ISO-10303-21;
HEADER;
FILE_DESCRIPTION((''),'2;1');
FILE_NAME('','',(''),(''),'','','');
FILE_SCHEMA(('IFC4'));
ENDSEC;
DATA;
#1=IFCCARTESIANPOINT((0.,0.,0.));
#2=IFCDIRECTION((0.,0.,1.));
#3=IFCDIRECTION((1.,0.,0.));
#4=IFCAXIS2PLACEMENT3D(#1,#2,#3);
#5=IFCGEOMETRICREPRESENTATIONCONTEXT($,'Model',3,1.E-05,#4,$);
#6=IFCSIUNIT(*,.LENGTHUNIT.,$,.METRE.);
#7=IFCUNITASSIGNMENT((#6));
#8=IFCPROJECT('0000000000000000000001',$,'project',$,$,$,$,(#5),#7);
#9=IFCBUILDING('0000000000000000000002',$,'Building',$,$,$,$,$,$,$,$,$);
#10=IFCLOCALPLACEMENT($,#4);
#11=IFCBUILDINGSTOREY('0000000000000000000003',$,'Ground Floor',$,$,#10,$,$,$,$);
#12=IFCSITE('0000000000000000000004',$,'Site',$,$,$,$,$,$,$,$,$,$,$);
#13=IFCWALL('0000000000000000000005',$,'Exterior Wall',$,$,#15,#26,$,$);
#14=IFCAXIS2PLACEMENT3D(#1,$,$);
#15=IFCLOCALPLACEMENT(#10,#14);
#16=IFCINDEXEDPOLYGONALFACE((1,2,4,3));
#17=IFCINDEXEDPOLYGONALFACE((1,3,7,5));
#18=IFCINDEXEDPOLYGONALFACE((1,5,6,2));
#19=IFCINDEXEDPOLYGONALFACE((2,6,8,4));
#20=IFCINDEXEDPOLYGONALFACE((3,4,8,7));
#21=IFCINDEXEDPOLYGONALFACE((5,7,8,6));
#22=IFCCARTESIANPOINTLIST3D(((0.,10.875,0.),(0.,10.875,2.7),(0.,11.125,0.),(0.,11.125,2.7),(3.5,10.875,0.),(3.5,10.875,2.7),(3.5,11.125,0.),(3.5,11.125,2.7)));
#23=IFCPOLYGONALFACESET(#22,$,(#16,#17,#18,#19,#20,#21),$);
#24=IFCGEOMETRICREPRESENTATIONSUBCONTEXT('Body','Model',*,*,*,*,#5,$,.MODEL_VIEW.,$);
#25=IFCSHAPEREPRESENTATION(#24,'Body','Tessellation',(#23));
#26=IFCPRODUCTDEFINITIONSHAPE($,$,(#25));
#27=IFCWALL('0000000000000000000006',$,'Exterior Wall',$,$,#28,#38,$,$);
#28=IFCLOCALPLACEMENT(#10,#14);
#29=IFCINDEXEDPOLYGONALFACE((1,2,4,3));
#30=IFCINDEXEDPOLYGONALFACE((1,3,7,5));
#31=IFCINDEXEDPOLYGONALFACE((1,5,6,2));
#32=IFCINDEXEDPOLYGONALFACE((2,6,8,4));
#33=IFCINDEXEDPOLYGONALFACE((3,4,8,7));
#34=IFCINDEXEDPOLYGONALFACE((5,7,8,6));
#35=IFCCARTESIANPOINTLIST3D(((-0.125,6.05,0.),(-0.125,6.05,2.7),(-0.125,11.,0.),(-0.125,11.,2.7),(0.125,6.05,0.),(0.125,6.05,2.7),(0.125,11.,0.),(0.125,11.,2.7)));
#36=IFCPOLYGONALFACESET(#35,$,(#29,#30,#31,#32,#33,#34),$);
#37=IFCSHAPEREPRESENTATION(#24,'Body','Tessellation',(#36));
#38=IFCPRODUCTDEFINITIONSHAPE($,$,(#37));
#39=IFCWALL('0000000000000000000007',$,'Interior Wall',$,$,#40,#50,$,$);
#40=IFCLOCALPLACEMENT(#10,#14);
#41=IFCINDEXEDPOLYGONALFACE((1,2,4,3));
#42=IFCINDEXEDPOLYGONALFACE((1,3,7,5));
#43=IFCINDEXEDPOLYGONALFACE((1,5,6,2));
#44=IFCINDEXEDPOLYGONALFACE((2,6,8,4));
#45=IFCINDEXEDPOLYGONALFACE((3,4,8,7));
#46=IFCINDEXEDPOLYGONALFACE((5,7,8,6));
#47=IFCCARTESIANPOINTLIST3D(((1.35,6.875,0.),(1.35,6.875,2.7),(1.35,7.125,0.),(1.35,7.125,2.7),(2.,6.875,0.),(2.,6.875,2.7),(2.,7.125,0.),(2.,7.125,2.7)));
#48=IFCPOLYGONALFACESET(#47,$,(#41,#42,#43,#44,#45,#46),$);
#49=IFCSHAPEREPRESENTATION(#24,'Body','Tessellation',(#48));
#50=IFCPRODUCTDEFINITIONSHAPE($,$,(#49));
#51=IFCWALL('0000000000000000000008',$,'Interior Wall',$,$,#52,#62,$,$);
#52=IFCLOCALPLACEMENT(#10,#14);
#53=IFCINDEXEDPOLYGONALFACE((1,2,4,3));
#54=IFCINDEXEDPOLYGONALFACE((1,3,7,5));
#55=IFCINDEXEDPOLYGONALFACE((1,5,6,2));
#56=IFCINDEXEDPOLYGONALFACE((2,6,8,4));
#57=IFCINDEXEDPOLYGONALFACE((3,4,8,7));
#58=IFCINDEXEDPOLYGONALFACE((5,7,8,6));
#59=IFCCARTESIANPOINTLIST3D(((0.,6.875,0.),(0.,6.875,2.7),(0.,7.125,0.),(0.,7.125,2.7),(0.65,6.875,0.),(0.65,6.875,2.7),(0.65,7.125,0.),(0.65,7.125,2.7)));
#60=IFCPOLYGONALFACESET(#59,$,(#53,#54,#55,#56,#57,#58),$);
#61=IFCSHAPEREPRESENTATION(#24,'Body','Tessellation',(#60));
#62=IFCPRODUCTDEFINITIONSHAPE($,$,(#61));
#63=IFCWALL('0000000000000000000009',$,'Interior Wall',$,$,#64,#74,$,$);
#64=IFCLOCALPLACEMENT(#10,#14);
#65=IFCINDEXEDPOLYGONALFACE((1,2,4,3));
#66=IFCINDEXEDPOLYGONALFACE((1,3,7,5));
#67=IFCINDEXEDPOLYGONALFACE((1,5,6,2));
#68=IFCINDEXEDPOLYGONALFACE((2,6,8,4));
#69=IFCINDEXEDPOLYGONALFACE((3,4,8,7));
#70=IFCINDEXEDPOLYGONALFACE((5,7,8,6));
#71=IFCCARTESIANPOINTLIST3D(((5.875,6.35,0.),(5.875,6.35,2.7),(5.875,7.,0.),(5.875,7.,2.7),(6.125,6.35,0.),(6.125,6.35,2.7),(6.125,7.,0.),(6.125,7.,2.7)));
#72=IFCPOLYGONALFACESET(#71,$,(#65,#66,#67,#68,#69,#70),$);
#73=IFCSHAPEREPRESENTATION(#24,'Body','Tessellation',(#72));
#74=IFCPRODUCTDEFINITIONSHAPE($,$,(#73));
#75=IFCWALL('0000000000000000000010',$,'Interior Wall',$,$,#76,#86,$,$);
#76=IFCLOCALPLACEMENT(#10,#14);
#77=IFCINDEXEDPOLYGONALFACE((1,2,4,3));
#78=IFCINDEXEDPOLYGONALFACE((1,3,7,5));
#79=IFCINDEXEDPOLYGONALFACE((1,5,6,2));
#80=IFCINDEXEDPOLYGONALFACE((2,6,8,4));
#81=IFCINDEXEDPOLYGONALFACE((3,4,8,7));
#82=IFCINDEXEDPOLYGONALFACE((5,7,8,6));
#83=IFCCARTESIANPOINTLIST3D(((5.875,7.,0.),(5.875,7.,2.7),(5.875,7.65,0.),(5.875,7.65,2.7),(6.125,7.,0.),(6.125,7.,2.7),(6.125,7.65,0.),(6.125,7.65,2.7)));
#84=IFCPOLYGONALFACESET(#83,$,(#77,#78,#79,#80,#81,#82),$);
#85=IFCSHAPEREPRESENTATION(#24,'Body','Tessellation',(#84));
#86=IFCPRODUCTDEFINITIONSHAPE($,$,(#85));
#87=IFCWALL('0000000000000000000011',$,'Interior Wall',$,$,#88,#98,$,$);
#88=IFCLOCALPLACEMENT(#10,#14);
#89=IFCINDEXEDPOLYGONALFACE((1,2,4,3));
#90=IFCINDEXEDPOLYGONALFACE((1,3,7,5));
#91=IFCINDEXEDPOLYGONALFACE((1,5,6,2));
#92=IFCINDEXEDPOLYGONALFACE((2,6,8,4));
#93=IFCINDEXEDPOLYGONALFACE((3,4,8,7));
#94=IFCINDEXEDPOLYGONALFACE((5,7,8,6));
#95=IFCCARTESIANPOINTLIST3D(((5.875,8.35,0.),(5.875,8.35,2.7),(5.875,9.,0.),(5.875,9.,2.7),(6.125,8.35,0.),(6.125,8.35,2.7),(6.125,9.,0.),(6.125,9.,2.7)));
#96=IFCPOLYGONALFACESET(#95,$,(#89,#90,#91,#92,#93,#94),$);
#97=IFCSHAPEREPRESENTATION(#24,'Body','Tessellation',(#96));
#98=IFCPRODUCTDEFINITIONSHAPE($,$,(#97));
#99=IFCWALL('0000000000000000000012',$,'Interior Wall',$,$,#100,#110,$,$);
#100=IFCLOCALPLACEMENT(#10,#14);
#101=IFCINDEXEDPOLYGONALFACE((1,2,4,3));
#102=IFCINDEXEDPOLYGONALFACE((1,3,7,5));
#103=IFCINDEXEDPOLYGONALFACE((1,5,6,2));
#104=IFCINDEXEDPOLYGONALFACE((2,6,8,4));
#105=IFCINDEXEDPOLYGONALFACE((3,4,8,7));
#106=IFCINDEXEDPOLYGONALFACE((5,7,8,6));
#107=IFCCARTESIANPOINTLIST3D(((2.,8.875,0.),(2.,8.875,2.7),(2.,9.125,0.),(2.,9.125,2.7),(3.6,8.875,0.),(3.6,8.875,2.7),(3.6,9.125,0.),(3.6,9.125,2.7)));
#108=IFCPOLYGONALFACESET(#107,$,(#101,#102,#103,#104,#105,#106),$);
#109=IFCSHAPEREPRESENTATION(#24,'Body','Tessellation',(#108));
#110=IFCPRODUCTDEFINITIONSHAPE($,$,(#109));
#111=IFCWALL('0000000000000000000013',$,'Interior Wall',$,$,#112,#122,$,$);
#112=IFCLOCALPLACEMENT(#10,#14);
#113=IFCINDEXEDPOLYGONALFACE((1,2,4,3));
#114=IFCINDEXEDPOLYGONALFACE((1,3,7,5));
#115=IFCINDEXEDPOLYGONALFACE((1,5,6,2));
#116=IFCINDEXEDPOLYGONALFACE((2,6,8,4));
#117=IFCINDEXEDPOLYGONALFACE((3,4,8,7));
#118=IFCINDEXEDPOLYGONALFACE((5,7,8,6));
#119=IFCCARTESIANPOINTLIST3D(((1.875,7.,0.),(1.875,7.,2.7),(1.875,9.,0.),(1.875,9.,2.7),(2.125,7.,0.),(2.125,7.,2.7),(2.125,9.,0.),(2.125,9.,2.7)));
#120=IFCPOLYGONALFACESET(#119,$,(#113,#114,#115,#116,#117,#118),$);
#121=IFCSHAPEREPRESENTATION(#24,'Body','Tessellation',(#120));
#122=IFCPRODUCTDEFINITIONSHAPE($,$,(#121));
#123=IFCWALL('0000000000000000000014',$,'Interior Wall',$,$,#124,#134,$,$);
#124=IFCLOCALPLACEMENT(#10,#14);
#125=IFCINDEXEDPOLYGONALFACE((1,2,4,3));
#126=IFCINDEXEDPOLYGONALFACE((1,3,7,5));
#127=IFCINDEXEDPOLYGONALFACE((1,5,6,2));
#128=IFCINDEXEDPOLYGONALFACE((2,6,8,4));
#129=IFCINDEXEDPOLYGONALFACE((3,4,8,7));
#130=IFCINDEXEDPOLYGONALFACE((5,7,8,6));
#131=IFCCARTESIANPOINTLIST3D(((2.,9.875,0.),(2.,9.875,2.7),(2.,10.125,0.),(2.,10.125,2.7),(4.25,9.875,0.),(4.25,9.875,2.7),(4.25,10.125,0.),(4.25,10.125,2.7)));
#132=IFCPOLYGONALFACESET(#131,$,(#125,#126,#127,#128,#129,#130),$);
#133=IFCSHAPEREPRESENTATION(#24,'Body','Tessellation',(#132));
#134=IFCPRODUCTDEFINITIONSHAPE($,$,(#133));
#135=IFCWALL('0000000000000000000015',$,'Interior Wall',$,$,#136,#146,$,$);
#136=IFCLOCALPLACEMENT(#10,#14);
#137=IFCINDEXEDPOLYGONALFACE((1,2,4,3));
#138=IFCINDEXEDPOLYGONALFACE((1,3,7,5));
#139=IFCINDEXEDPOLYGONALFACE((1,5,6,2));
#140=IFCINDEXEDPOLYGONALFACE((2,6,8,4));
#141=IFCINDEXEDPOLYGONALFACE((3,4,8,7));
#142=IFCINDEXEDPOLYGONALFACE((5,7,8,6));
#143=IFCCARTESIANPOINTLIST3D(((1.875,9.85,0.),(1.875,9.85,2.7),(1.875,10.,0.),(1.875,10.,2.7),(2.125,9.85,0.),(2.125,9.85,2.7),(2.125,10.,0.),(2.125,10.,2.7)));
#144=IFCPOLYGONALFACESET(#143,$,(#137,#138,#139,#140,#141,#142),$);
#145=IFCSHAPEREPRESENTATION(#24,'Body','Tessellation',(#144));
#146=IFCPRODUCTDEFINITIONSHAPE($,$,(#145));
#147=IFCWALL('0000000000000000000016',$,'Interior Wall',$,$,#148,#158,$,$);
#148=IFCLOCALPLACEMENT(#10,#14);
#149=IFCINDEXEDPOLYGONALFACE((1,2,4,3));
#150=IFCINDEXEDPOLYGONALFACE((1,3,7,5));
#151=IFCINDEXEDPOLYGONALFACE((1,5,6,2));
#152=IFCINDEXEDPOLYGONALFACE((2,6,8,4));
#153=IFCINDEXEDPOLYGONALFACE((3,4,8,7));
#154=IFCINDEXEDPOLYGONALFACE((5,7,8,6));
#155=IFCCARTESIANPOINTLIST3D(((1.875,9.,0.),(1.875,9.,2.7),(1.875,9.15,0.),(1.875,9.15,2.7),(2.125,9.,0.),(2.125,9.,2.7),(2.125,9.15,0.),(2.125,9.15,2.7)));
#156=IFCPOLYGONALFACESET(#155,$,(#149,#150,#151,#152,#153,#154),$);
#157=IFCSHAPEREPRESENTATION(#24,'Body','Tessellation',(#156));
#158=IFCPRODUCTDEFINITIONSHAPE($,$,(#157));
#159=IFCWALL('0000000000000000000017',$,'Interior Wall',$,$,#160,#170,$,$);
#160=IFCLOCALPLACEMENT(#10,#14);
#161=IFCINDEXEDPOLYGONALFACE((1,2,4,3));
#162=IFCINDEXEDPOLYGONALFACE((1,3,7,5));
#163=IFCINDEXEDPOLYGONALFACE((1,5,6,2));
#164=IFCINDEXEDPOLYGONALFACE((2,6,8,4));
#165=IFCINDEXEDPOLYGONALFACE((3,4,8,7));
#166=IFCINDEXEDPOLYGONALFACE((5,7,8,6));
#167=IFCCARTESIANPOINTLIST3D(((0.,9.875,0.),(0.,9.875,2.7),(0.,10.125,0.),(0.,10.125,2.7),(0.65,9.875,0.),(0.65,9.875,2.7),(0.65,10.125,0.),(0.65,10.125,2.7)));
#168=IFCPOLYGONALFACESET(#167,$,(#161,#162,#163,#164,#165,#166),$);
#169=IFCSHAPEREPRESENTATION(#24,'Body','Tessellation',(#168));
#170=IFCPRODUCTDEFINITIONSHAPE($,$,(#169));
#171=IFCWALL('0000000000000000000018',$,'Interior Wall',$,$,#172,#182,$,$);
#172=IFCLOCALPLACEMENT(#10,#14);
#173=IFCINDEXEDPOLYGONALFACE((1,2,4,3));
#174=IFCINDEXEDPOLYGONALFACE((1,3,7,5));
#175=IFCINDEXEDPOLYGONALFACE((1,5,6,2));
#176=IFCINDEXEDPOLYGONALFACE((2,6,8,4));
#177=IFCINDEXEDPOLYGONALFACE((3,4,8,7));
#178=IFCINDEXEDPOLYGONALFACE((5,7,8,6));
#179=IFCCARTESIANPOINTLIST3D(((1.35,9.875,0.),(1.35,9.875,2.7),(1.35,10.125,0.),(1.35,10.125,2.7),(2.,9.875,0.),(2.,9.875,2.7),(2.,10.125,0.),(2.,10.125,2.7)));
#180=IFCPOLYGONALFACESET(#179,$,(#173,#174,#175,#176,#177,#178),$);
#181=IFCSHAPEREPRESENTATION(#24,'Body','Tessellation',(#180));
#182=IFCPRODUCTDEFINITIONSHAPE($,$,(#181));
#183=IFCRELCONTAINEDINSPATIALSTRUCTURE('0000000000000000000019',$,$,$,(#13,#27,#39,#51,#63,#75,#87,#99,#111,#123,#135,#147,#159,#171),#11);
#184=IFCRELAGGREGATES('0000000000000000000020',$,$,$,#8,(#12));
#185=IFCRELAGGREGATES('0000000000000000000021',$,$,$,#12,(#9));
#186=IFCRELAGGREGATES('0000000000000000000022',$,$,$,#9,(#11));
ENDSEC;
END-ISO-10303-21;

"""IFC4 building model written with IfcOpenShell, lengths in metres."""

from ifc_helpers import new_model, si_unit, frame, origin_with_axes, place, context, subcontext, project, spatial, indexed_curve, outline, extrude, element, save


model = new_model("IFC4")

# Units and contexts
model_context = context("Model", 3, precision=1e-05, world=origin_with_axes())
body_context = subcontext(model_context, "Body", "Model", "MODEL_VIEW")
ifc_project = project(units=[si_unit("LENGTHUNIT", "METRE")], contexts=[model_context])

# Site, building, storey
site = spatial("IfcSite", under=ifc_project, Name="Site")
building = spatial("IfcBuilding", under=site, Name="Building")
storey_placement = place(None, origin_with_axes())
storey = spatial("IfcBuildingStorey", under=building, at=storey_placement, Name="Ground Floor")

# Walls
wall_1_placement = place(storey_placement, frame((3.5, 11.0, 0.0), z_axis=(0.0, 0.0, 1.0), x_axis=(-1.0, 0.0, 0.0)))
element("IfcWall", 1, at=wall_1_placement, inside=storey, Name="Exterior Wall", context=body_context, shape_type="SweptSolid", body=[
    extrude(outline(indexed_curve([(0.0, 0.0), (0.0, 0.25), (3.5, 0.25), (3.5, 0.0), (0.0, 0.0)], self_intersect=False)), frame((0.0, -0.125, 0.0), z_axis=(0.0, 0.0, 1.0), x_axis=(1.0, 0.0, 0.0)), (0.0, 0.0, 1.0), 2.7),
])
wall_2_placement = place(storey_placement, frame((0.0, 11.0, 0.0), z_axis=(0.0, 0.0, 1.0), x_axis=(0.0, -1.0, 0.0)))
element("IfcWall", 2, at=wall_2_placement, inside=storey, Name="Exterior Wall", context=body_context, shape_type="SweptSolid", body=[
    extrude(outline(indexed_curve([(0.0, 0.0), (0.0, 0.25), (4.95, 0.25), (4.95, 0.0), (0.0, 0.0)], self_intersect=False)), frame((0.0, -0.125, 0.0), z_axis=(0.0, 0.0, 1.0), x_axis=(1.0, 0.0, 0.0)), (0.0, 0.0, 1.0), 2.7),
])
for number, where, z_axis, x_axis, name in (
    (3, (2.0, 7.0, 0.0), (0.0, 0.0, 1.0), (-1.0, 0.0, 0.0), "Interior Wall"),
    (4, (0.65, 7.0, 0.0), (0.0, 0.0, 1.0), (-1.0, 0.0, 0.0), "Interior Wall"),
):
    element("IfcWall", number, at=place(storey_placement, frame(where, z_axis=z_axis, x_axis=x_axis)), inside=storey, Name=name, context=body_context, shape_type="SweptSolid", body=[
        extrude(outline(indexed_curve([(0.0, 0.0), (0.0, 0.25), (0.65, 0.25), (0.65, 0.0), (0.0, 0.0)], self_intersect=False)), frame((0.0, -0.125, 0.0), z_axis=(0.0, 0.0, 1.0), x_axis=(1.0, 0.0, 0.0)), (0.0, 0.0, 1.0), 2.7),
    ])
for number, where, z_axis, x_axis, name in (
    (5, (6.0, 6.35, 0.0), (0.0, 0.0, 1.0), (0.0, 1.0, 0.0), "Interior Wall"),
    (6, (6.0, 7.0, 0.0), (0.0, 0.0, 1.0), (0.0, 1.0, 0.0), "Interior Wall"),
    (7, (6.0, 8.35, 0.0), (0.0, 0.0, 1.0), (0.0, 1.0, 0.0), "Interior Wall"),
):
    element("IfcWall", number, at=place(storey_placement, frame(where, z_axis=z_axis, x_axis=x_axis)), inside=storey, Name=name, context=body_context, shape_type="SweptSolid", body=[
        extrude(outline(indexed_curve([(0.0, 0.0), (0.0, 0.25), (0.65, 0.25), (0.65, 0.0), (0.0, 0.0)], self_intersect=False)), frame((0.0, -0.125, 0.0), z_axis=(0.0, 0.0, 1.0), x_axis=(1.0, 0.0, 0.0)), (0.0, 0.0, 1.0), 2.7),
    ])
wall_3_placement = place(storey_placement, frame((3.6, 9.0, 0.0), z_axis=(0.0, 0.0, 1.0), x_axis=(-1.0, 0.0, 0.0)))
element("IfcWall", 8, at=wall_3_placement, inside=storey, Name="Interior Wall", context=body_context, shape_type="SweptSolid", body=[
    extrude(outline(indexed_curve([(0.0, 0.0), (0.0, 0.25), (1.6, 0.25), (1.6, 0.0), (0.0, 0.0)], self_intersect=False)), frame((0.0, -0.125, 0.0), z_axis=(0.0, 0.0, 1.0), x_axis=(1.0, 0.0, 0.0)), (0.0, 0.0, 1.0), 2.7),
])
wall_4_placement = place(storey_placement, frame((2.0, 9.0, 0.0), z_axis=(0.0, 0.0, 1.0), x_axis=(0.0, -1.0, 0.0)))
element("IfcWall", 9, at=wall_4_placement, inside=storey, Name="Interior Wall", context=body_context, shape_type="SweptSolid", body=[
    extrude(outline(indexed_curve([(0.0, 0.0), (0.0, 0.25), (2.0, 0.25), (2.0, 0.0), (0.0, 0.0)], self_intersect=False)), frame((0.0, -0.125, 0.0), z_axis=(0.0, 0.0, 1.0), x_axis=(1.0, 0.0, 0.0)), (0.0, 0.0, 1.0), 2.7),
])
wall_5_placement = place(storey_placement, frame((4.25, 10.0, 0.0), z_axis=(0.0, 0.0, 1.0), x_axis=(-1.0, 0.0, 0.0)))
element("IfcWall", 10, at=wall_5_placement, inside=storey, Name="Interior Wall", context=body_context, shape_type="SweptSolid", body=[
    extrude(outline(indexed_curve([(0.0, 0.0), (0.0, 0.25), (2.25, 0.25), (2.25, 0.0), (0.0, 0.0)], self_intersect=False)), frame((0.0, -0.125, 0.0), z_axis=(0.0, 0.0, 1.0), x_axis=(1.0, 0.0, 0.0)), (0.0, 0.0, 1.0), 2.7),
])
for number, where, z_axis, x_axis, name in (
    (11, (2.0, 10.0, 0.0), (0.0, 0.0, 1.0), (0.0, -1.0, 0.0), "Interior Wall"),
    (12, (2.0, 9.15, 0.0), (0.0, 0.0, 1.0), (0.0, -1.0, 0.0), "Interior Wall"),
):
    element("IfcWall", number, at=place(storey_placement, frame(where, z_axis=z_axis, x_axis=x_axis)), inside=storey, Name=name, context=body_context, shape_type="SweptSolid", body=[
        extrude(outline(indexed_curve([(0.0, 0.0), (0.0, 0.25), (0.15, 0.25), (0.15, 0.0), (0.0, 0.0)], self_intersect=False)), frame((0.0, -0.125, 0.0), z_axis=(0.0, 0.0, 1.0), x_axis=(1.0, 0.0, 0.0)), (0.0, 0.0, 1.0), 2.7),
    ])
wall_6_placement = place(storey_placement, frame((0.0, 10.0, 0.0), z_axis=(0.0, 0.0, 1.0), x_axis=(1.0, 0.0, 0.0)))
element("IfcWall", 13, at=wall_6_placement, inside=storey, Name="Interior Wall", context=body_context, shape_type="SweptSolid", body=[
    extrude(outline(indexed_curve([(0.0, 0.0), (0.0, 0.25), (0.65, 0.25), (0.65, 0.0), (0.0, 0.0)], self_intersect=False)), frame((0.0, -0.125, 0.0), z_axis=(0.0, 0.0, 1.0), x_axis=(1.0, 0.0, 0.0)), (0.0, 0.0, 1.0), 2.7),
])
wall_7_placement = place(storey_placement, frame((1.35, 10.0, 0.0), z_axis=(0.0, 0.0, 1.0), x_axis=(1.0, 0.0, 0.0)))
element("IfcWall", 14, at=wall_7_placement, inside=storey, Name="Interior Wall", context=body_context, shape_type="SweptSolid", body=[
    extrude(outline(indexed_curve([(0.0, 0.0), (0.0, 0.25), (0.65, 0.25), (0.65, 0.0), (0.0, 0.0)], self_intersect=False)), frame((0.0, -0.125, 0.0), z_axis=(0.0, 0.0, 1.0), x_axis=(1.0, 0.0, 0.0)), (0.0, 0.0, 1.0), 2.7),
])

save(model, "model.ifc")
